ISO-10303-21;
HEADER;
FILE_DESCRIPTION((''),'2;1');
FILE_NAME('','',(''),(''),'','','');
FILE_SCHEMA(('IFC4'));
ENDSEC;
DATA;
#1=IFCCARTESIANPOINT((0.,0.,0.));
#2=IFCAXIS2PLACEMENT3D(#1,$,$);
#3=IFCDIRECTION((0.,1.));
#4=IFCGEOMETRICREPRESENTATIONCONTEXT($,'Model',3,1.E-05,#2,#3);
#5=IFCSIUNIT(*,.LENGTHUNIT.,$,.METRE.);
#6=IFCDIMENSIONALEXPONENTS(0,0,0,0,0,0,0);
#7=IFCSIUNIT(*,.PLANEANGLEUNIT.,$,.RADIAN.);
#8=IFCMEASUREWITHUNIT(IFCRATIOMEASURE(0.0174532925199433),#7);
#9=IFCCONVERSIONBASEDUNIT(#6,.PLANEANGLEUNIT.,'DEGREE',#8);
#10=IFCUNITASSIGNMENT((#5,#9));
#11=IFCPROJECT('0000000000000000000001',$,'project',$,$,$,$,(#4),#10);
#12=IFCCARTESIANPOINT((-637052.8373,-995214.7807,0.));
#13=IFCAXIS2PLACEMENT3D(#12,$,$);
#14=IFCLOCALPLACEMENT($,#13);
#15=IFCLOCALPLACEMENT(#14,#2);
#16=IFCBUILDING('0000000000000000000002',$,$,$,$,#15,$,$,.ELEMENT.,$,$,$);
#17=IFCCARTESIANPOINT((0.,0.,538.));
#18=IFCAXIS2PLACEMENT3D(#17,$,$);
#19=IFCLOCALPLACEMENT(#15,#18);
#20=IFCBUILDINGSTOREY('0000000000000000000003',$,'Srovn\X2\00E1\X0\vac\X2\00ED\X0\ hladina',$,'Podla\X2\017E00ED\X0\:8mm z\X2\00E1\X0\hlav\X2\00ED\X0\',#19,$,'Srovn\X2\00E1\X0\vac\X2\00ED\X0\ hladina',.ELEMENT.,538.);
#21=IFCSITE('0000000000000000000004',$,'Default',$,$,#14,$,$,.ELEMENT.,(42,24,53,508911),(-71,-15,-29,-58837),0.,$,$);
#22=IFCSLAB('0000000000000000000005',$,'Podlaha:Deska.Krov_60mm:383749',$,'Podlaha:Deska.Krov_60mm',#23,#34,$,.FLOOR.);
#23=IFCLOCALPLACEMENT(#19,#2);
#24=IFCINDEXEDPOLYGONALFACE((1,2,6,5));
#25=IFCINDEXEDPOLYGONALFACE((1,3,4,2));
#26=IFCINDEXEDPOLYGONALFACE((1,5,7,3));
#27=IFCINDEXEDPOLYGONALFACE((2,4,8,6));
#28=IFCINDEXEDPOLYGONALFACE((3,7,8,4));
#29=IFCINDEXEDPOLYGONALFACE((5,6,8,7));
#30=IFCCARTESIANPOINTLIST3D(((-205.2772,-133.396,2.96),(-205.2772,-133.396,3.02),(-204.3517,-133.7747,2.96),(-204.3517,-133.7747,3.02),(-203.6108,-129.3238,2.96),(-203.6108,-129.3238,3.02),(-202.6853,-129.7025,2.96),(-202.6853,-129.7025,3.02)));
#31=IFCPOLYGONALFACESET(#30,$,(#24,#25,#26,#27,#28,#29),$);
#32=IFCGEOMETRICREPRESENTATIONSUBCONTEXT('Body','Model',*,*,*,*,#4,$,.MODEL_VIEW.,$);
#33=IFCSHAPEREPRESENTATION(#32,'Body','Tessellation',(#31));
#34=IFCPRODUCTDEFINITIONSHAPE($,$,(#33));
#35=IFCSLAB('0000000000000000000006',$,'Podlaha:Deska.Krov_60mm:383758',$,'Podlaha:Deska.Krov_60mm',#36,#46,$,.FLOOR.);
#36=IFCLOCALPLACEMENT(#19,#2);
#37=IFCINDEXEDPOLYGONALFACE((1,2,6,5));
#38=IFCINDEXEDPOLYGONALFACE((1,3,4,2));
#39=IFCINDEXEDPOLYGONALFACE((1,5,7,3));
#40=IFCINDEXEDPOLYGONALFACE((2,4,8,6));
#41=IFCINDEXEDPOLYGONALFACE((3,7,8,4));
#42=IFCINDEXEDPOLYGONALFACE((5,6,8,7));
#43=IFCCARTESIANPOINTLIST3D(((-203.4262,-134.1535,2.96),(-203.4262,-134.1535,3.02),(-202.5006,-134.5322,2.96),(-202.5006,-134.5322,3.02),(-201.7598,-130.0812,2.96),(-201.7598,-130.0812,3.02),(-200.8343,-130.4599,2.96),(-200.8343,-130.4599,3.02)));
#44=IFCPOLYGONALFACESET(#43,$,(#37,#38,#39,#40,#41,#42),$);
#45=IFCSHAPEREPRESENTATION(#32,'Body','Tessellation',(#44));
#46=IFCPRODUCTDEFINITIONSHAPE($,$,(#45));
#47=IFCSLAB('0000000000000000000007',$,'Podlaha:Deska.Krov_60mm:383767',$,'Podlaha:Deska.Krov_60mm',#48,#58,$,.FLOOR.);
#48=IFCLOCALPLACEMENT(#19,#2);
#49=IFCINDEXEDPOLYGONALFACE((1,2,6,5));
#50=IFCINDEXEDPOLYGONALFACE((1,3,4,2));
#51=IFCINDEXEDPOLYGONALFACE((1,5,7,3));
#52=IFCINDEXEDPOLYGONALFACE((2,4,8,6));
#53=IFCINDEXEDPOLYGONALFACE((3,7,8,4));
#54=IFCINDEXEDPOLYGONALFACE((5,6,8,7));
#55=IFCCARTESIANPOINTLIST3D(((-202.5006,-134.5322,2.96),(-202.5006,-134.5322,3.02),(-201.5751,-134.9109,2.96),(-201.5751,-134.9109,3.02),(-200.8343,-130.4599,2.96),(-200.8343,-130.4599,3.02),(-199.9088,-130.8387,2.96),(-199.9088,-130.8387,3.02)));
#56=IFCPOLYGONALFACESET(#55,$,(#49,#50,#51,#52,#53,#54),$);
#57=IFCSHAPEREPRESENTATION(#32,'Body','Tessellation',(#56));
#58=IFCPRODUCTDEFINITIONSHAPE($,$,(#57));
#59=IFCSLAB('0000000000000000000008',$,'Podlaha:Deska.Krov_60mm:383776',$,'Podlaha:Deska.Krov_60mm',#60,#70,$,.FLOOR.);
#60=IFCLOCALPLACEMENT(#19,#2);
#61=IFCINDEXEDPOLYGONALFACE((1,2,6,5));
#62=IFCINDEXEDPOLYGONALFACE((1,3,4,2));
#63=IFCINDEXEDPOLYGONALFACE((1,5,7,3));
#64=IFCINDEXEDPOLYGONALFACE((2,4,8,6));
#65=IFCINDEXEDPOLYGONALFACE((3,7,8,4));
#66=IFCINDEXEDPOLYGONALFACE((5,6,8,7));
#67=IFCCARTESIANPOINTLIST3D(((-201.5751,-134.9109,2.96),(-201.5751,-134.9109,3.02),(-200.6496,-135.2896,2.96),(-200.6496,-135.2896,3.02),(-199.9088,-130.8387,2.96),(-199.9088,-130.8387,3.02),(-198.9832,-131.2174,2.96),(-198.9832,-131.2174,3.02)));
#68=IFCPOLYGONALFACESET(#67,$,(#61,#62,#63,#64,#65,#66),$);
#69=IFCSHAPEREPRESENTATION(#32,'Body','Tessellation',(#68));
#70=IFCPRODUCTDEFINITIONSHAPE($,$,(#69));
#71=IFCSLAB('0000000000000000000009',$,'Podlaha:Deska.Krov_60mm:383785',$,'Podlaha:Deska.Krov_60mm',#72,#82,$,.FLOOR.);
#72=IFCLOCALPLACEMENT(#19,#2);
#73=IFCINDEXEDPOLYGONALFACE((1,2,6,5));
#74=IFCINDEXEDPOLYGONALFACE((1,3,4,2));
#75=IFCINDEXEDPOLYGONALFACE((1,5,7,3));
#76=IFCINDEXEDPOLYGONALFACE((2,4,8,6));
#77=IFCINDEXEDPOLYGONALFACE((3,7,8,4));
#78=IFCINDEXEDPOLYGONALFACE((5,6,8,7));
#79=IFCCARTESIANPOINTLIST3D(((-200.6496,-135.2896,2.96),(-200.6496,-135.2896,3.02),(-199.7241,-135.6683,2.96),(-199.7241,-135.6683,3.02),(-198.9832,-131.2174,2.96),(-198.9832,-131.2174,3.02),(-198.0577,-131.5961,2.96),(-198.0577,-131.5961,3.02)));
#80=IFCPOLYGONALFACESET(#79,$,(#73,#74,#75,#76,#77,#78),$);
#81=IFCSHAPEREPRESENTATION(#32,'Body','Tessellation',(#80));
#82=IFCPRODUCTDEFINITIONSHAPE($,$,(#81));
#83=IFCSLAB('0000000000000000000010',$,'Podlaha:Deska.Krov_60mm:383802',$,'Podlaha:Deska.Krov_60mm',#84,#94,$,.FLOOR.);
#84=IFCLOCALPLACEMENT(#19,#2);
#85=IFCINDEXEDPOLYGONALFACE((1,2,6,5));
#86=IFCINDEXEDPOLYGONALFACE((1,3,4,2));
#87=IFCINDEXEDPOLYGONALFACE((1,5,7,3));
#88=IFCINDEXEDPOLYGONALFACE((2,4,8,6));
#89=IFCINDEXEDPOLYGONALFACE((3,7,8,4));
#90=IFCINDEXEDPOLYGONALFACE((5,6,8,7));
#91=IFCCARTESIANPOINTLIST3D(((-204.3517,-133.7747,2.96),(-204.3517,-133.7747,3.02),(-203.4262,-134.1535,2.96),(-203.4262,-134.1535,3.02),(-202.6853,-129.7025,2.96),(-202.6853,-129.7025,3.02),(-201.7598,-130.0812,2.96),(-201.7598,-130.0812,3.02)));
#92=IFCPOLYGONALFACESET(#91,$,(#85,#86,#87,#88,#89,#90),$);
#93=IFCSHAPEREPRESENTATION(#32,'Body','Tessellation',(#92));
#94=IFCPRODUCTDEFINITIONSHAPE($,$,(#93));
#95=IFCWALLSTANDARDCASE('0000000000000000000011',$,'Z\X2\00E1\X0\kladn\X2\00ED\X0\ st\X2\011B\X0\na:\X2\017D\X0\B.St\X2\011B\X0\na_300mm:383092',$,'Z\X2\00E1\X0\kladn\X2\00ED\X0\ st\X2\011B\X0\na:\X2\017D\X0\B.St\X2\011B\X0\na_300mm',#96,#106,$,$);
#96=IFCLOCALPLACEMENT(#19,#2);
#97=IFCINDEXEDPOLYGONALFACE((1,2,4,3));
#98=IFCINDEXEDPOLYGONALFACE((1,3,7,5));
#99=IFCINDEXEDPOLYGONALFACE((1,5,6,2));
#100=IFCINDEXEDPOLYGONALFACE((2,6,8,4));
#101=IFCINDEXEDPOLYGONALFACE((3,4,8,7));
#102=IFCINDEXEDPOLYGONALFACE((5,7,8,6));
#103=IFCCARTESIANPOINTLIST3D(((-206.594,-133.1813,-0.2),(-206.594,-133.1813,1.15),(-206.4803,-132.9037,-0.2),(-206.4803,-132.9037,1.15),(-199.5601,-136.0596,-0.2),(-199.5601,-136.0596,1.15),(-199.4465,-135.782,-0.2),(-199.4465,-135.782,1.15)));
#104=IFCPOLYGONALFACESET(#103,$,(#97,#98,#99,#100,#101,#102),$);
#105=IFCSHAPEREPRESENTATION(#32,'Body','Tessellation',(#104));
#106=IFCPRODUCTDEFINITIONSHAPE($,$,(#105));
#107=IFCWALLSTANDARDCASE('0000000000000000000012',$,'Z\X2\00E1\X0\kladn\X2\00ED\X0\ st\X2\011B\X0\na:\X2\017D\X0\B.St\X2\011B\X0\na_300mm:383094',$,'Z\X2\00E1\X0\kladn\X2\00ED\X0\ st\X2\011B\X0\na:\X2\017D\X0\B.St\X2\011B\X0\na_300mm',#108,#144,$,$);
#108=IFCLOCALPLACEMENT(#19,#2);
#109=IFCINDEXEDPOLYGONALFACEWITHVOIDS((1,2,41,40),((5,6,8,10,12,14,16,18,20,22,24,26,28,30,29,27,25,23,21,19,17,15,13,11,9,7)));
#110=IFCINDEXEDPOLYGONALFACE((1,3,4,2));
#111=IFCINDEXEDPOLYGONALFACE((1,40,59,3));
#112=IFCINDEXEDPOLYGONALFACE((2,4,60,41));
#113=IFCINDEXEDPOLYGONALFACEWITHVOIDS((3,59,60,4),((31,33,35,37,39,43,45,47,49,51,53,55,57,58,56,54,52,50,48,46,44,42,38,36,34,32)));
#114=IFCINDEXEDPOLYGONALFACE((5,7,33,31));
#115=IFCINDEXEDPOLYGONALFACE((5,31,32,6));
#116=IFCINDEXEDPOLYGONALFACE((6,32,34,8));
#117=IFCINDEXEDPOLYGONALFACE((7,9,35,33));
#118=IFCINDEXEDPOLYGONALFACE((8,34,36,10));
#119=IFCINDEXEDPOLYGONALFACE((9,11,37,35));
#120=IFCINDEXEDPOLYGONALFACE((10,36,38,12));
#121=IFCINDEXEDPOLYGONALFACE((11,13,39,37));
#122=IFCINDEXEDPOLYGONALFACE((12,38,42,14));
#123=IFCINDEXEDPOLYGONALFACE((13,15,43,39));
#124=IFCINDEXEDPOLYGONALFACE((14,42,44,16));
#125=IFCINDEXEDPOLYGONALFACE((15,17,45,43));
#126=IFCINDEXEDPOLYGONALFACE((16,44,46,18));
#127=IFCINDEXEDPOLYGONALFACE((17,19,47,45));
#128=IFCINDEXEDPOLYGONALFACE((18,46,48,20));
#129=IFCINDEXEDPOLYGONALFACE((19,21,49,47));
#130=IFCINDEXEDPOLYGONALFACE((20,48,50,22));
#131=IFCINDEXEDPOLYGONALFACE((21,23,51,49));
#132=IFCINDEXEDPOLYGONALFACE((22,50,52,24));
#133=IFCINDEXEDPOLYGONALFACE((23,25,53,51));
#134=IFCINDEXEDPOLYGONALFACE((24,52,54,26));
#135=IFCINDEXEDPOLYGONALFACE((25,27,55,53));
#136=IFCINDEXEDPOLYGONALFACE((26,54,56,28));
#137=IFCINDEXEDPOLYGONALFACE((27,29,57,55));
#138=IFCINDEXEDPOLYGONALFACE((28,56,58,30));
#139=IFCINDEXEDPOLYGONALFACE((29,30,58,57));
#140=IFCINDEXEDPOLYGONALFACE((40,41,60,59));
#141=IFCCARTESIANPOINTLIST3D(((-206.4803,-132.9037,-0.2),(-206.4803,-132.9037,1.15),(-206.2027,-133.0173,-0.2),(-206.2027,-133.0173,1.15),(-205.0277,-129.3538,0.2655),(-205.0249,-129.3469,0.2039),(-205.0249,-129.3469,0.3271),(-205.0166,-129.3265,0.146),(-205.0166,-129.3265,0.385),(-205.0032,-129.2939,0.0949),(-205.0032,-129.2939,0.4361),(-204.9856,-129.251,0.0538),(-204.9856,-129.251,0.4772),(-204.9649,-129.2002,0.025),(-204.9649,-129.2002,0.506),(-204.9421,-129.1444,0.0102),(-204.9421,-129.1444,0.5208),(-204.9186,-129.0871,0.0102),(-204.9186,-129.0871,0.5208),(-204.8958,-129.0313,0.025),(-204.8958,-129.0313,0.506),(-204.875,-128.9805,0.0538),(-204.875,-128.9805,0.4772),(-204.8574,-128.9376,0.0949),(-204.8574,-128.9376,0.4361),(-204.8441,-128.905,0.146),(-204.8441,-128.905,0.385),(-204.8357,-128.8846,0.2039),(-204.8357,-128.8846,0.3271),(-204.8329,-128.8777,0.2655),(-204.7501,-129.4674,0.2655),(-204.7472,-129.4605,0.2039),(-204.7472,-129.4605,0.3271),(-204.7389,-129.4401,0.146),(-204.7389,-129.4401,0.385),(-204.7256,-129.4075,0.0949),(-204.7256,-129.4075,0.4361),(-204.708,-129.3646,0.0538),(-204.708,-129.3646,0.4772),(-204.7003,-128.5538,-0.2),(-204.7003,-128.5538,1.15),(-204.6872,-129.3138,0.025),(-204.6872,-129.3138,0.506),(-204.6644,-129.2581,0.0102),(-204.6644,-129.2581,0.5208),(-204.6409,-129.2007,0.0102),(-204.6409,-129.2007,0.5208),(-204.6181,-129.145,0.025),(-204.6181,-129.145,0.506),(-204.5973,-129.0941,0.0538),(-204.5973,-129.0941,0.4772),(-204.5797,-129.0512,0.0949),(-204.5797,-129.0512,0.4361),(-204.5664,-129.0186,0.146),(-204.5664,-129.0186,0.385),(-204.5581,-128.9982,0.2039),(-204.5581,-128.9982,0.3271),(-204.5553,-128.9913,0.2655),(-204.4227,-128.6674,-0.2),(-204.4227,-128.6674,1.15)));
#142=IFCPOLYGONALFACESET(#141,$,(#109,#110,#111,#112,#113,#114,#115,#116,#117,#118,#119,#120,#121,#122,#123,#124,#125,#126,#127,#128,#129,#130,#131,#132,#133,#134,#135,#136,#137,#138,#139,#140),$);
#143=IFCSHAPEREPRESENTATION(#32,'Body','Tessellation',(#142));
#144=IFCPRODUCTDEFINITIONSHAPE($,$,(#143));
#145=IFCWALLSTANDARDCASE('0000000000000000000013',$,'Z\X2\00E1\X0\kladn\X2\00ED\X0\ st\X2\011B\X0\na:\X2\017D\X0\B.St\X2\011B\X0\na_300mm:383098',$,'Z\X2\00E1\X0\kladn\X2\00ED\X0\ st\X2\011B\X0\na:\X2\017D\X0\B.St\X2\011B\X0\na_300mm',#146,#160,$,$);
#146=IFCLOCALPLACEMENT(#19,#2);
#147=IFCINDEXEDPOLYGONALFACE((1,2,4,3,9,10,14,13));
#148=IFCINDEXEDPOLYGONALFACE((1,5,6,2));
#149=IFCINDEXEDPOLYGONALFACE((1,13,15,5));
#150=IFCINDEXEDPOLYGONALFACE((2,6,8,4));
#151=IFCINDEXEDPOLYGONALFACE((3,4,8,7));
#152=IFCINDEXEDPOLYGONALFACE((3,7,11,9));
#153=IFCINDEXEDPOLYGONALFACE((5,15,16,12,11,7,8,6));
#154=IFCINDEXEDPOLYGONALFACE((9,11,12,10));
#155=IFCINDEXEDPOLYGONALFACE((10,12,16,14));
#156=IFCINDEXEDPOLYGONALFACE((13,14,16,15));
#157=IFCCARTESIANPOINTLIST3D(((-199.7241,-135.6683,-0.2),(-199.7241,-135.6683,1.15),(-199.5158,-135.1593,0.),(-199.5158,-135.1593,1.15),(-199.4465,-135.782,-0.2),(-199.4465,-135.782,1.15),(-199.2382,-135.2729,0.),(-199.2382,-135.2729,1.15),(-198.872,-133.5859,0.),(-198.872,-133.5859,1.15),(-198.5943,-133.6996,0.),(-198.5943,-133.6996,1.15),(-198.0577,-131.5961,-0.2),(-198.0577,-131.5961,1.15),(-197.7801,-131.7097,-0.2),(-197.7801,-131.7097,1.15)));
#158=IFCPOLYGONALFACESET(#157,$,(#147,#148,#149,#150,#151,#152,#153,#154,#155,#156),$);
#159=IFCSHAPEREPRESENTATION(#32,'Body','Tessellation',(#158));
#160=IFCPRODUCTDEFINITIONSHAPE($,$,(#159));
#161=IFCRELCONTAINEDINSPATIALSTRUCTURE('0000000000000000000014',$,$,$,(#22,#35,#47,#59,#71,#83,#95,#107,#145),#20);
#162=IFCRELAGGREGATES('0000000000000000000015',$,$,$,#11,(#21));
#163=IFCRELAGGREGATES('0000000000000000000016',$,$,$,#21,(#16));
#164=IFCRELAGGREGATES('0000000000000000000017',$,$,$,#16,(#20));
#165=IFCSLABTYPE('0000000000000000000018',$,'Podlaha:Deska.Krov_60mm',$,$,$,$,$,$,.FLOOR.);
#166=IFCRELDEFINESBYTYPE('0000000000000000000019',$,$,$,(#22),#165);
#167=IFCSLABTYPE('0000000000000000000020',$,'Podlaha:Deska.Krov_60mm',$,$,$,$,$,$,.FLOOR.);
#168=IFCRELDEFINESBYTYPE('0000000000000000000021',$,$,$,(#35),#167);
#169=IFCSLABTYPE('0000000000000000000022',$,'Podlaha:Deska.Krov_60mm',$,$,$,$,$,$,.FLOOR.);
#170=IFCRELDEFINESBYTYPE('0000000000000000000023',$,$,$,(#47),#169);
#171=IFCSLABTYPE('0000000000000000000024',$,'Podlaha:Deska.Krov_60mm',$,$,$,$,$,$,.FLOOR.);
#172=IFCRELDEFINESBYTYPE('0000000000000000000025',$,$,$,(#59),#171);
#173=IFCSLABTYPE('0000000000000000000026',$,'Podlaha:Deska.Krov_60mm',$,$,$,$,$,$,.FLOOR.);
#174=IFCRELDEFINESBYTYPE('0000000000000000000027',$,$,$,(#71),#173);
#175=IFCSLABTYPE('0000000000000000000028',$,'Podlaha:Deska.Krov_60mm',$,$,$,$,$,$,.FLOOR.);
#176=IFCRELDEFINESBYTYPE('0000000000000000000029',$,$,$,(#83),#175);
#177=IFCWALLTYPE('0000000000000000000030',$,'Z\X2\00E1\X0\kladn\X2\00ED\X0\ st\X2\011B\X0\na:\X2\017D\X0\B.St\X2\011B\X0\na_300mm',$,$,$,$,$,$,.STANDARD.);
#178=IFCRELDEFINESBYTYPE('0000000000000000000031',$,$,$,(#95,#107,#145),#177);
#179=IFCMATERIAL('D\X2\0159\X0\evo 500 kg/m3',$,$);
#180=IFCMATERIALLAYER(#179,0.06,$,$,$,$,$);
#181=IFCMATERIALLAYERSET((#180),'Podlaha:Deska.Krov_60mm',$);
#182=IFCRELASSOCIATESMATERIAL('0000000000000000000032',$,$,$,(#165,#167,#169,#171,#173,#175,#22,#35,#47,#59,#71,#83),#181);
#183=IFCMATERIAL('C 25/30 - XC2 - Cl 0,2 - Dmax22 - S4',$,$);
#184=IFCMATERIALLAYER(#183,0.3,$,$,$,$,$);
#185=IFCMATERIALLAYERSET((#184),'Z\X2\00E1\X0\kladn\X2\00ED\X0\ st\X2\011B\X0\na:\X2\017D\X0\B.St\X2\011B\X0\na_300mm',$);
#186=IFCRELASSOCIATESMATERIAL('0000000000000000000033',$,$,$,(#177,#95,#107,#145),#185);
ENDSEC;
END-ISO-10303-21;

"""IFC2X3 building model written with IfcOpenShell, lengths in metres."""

from ifc_helpers import new_model, entity, si_unit, converted_unit, direction, frame, frame_2d, origin, origin_2d_with_axis, place, context, subcontext, project, spatial, rectangle, circle, extrude, material, layer, layer_set, layer_usage, type_object, element, save


model = new_model("IFC2X3")

# Units and contexts
model_context = context("Model", 3, precision=1e-05, world=origin(), true_north=direction((0.0, 1.0)))
body_context = subcontext(model_context, "Body", "Model", "MODEL_VIEW")
ifc_project = project(units=[si_unit("LENGTHUNIT", "METRE"), converted_unit("PLANEANGLEUNIT", "DEGREE", entity("IfcRatioMeasure", 0.0174532925199433), si_unit("PLANEANGLEUNIT", "RADIAN"), dimensions=[0, 0, 0, 0, 0, 0, 0])], contexts=[model_context])

# Site, building, storey
site_placement = place(None, frame((-637052.8373, -995214.7807, 0.0)))
site = spatial("IfcSite", under=ifc_project, at=site_placement, Name="Default", CompositionType="ELEMENT", RefLatitude=(42, 24, 53, 508911), RefLongitude=(-71, -15, -29, -58837), RefElevation=0.0)
building_placement = place(site_placement, origin())
building = spatial("IfcBuilding", under=site, at=building_placement, CompositionType="ELEMENT")
storey_placement = place(building_placement, frame((0.0, 0.0, 538.0)))
storey = spatial("IfcBuildingStorey", under=building, at=storey_placement, Name="Srovnávací hladina", ObjectType="Podlaží:8mm záhlaví", LongName="Srovnávací hladina", CompositionType="ELEMENT", Elevation=538.0)

# Slabs
ifc_material_1 = material(Name="Dřevo 500 kg/m3")
ifc_layer_1 = layer(ifc_material_1, 0.06)
ifc_layer_set_1 = layer_set([ifc_layer_1], Name="Podlaha:Deska.Krov_60mm")
ifc_layer_usage_1 = layer_usage(ifc_layer_set_1, "AXIS3", "POSITIVE", 0.0)
slab_type_1 = type_object("IfcSlabType", Name="Podlaha:Deska.Krov_60mm", PredefinedType="FLOOR", material=ifc_layer_set_1)
slab_1_placement = place(storey_placement, origin())
element("IfcSlab", 1, at=slab_1_placement, inside=storey, type_object=slab_type_1, material=ifc_layer_usage_1, Name="Podlaha:Deska.Krov_60mm:383749", ObjectType="Podlaha:Deska.Krov_60mm", PredefinedType="FLOOR", context=body_context, shape_type="SweptSolid", body=[
    extrude(rectangle(XDim=4.4, YDim=1.0, at=frame_2d((0.0, 0.0), x_axis=(1.0, 0.0))), frame((-203.9812, -131.5492, 3.02), z_axis=(0.0, 0.0, -1.0), x_axis=(-0.378722, -0.92551, 0.0)), (0.0, 0.0, 1.0), 0.06),
])
ifc_layer_usage_2 = layer_usage(ifc_layer_set_1, "AXIS3", "POSITIVE", 0.0)
slab_type_2 = type_object("IfcSlabType", Name="Podlaha:Deska.Krov_60mm", PredefinedType="FLOOR", material=ifc_layer_set_1)
slab_2_placement = place(storey_placement, origin())
element("IfcSlab", 2, at=slab_2_placement, inside=storey, type_object=slab_type_2, material=ifc_layer_usage_2, Name="Podlaha:Deska.Krov_60mm:383758", ObjectType="Podlaha:Deska.Krov_60mm", PredefinedType="FLOOR", context=body_context, shape_type="SweptSolid", body=[
    extrude(rectangle(XDim=4.4, YDim=1.0, at=frame_2d((0.0, 0.0), x_axis=(1.0, 0.0))), frame((-202.1302, -132.3067, 3.02), z_axis=(0.0, 0.0, -1.0), x_axis=(-0.378722, -0.92551, 0.0)), (0.0, 0.0, 1.0), 0.06),
])
ifc_layer_usage_3 = layer_usage(ifc_layer_set_1, "AXIS3", "POSITIVE", 0.0)
slab_type_3 = type_object("IfcSlabType", Name="Podlaha:Deska.Krov_60mm", PredefinedType="FLOOR", material=ifc_layer_set_1)
slab_3_placement = place(storey_placement, origin())
element("IfcSlab", 3, at=slab_3_placement, inside=storey, type_object=slab_type_3, material=ifc_layer_usage_3, Name="Podlaha:Deska.Krov_60mm:383767", ObjectType="Podlaha:Deska.Krov_60mm", PredefinedType="FLOOR", context=body_context, shape_type="SweptSolid", body=[
    extrude(rectangle(XDim=4.4, YDim=1.0, at=origin_2d_with_axis()), frame((-201.2047, -132.6854, 3.02), z_axis=(0.0, 0.0, -1.0), x_axis=(-0.378722, -0.92551, 0.0)), (0.0, 0.0, 1.0), 0.06),
])
ifc_layer_usage_4 = layer_usage(ifc_layer_set_1, "AXIS3", "POSITIVE", 0.0)
slab_type_4 = type_object("IfcSlabType", Name="Podlaha:Deska.Krov_60mm", PredefinedType="FLOOR", material=ifc_layer_set_1)
slab_4_placement = place(storey_placement, origin())
element("IfcSlab", 4, at=slab_4_placement, inside=storey, type_object=slab_type_4, material=ifc_layer_usage_4, Name="Podlaha:Deska.Krov_60mm:383776", ObjectType="Podlaha:Deska.Krov_60mm", PredefinedType="FLOOR", context=body_context, shape_type="SweptSolid", body=[
    extrude(rectangle(XDim=4.4, YDim=1.0, at=frame_2d((0.0, 0.0), x_axis=(1.0, 0.0))), frame((-200.2792, -133.0641, 3.02), z_axis=(0.0, 0.0, -1.0), x_axis=(-0.378722, -0.92551, 0.0)), (0.0, 0.0, 1.0), 0.06),
])
ifc_layer_usage_5 = layer_usage(ifc_layer_set_1, "AXIS3", "POSITIVE", 0.0)
slab_type_5 = type_object("IfcSlabType", Name="Podlaha:Deska.Krov_60mm", PredefinedType="FLOOR", material=ifc_layer_set_1)
slab_5_placement = place(storey_placement, origin())
element("IfcSlab", 5, at=slab_5_placement, inside=storey, type_object=slab_type_5, material=ifc_layer_usage_5, Name="Podlaha:Deska.Krov_60mm:383785", ObjectType="Podlaha:Deska.Krov_60mm", PredefinedType="FLOOR", context=body_context, shape_type="SweptSolid", body=[
    extrude(rectangle(XDim=4.4, YDim=1.0, at=frame_2d((0.0, 0.0), x_axis=(1.0, 0.0))), frame((-199.3537, -133.4429, 3.02), z_axis=(0.0, 0.0, -1.0), x_axis=(-0.378722, -0.92551, 0.0)), (0.0, 0.0, 1.0), 0.06),
])
ifc_layer_usage_6 = layer_usage(ifc_layer_set_1, "AXIS3", "POSITIVE", 0.0)
slab_type_6 = type_object("IfcSlabType", Name="Podlaha:Deska.Krov_60mm", PredefinedType="FLOOR", material=ifc_layer_set_1)
slab_6_placement = place(storey_placement, origin())
element("IfcSlab", 6, at=slab_6_placement, inside=storey, type_object=slab_type_6, material=ifc_layer_usage_6, Name="Podlaha:Deska.Krov_60mm:383802", ObjectType="Podlaha:Deska.Krov_60mm", PredefinedType="FLOOR", context=body_context, shape_type="SweptSolid", body=[
    extrude(rectangle(XDim=4.4, YDim=1.0, at=origin_2d_with_axis()), frame((-203.0557, -131.928, 3.02), z_axis=(0.0, 0.0, -1.0), x_axis=(-0.378722, -0.92551, 0.0)), (0.0, 0.0, 1.0), 0.06),
])

# Walls, openings
ifc_material_2 = material(Name="C 25/30 - XC2 - Cl 0,2 - Dmax22 - S4")
ifc_layer_2 = layer(ifc_material_2, 0.3)
ifc_layer_set_2 = layer_set([ifc_layer_2], Name="Základní stěna:ŽB.Stěna_300mm")
ifc_layer_usage_7 = layer_usage(ifc_layer_set_2, "AXIS2", "POSITIVE", -0.15)
wall_type = type_object("IfcWallType", Name="Základní stěna:ŽB.Stěna_300mm", PredefinedType="STANDARD", material=ifc_layer_set_2)
wall_1_placement = place(storey_placement, frame((-199.5033, -135.9208, -0.2), z_axis=(0.0, 0.0, 1.0), x_axis=(-0.92551, 0.378722, 0.0)))
wall_1 = element("IfcWallStandardCase", 7, at=wall_1_placement, inside=storey, type_object=wall_type, material=ifc_layer_usage_7, Name="Základní stěna:ŽB.Stěna_300mm:383092", ObjectType="Základní stěna:ŽB.Stěna_300mm", context=body_context, shape_type="SweptSolid", body=[
    extrude(rectangle(XDim=7.6, YDim=0.3, at=frame_2d((3.8, 0.0), x_axis=(-1.0, 0.0))), origin(), (0.0, 0.0, 1.0), 1.35),
])
opening_1_placement = place(wall_1_placement, origin())
element("IfcOpeningElement", 8, at=opening_1_placement, cuts=wall_1, ObjectType="Opening", context=body_context, shape_type="SweptSolid", body=[
    extrude(rectangle(XDim=2.2, YDim=0.3, at=frame_2d((0.0, 0.0), x_axis=(0.0, 1.0))), frame((0.15, -2.4, 1.3), z_axis=(0.0, 1.0, 0.0), x_axis=(1.0, 0.0, 0.0)), (0.0, 0.0, 1.0), 1.7),
])
ifc_layer_usage_8 = layer_usage(ifc_layer_set_2, "AXIS2", "POSITIVE", -0.15)
wall_2_placement = place(storey_placement, frame((-206.3415, -132.9605, -0.2), z_axis=(0.0, 0.0, 1.0), x_axis=(0.378722, 0.92551, 0.0)))
wall_2 = element("IfcWallStandardCase", 9, at=wall_2_placement, inside=storey, type_object=wall_type, material=ifc_layer_usage_8, Name="Základní stěna:ŽB.Stěna_300mm:383094", ObjectType="Základní stěna:ŽB.Stěna_300mm", context=body_context, shape_type="SweptSolid", body=[
    extrude(rectangle(XDim=4.7, YDim=0.3, at=frame_2d((2.35, 0.0), x_axis=(-1.0, 0.0))), origin(), (0.0, 0.0, 1.0), 1.35),
])
opening_2_placement = place(wall_2_placement, origin())
element("IfcOpeningElement", 10, at=opening_2_placement, cuts=wall_2, ObjectType="Opening", context=body_context, shape_type="SweptSolid", body=[
    extrude(circle(Radius=0.2572, at=origin_2d_with_axis()), frame((4.0928, 0.15, 0.4655), z_axis=(0.0, -1.0, 0.0), x_axis=(-1.0, 0.0, 0.0)), (0.0, 0.0, 1.0), 0.3),
])
ifc_layer_usage_9 = layer_usage(ifc_layer_set_2, "AXIS2", "POSITIVE", -0.15)
wall_3_placement = place(storey_placement, frame((-197.9189, -131.6529, -0.2), z_axis=(0.0, 0.0, 1.0), x_axis=(-0.378722, -0.92551, 0.0)))
wall_3 = element("IfcWallStandardCase", 11, at=wall_3_placement, inside=storey, type_object=wall_type, material=ifc_layer_usage_9, Name="Základní stěna:ŽB.Stěna_300mm:383098", ObjectType="Základní stěna:ŽB.Stěna_300mm", context=body_context, shape_type="SweptSolid", body=[
    extrude(rectangle(XDim=4.4, YDim=0.3, at=frame_2d((2.2, 0.0), x_axis=(-1.0, 0.0))), origin(), (0.0, 0.0, 1.0), 1.35),
])
opening_3_placement = place(wall_3_placement, origin())
element("IfcOpeningElement", 12, at=opening_3_placement, cuts=wall_3, ObjectType="Opening", context=body_context, shape_type="SweptSolid", body=[
    extrude(rectangle(XDim=2.2, YDim=1.7, at=frame_2d((0.0, 0.0), x_axis=(1.0, 0.0))), frame((3.0, -1.674, 1.3), z_axis=(0.0, 1.0, 0.0), x_axis=(0.0, 0.0, 1.0)), (0.0, 0.0, 1.0), 3.048),
])

save(model, "model.ifc")
